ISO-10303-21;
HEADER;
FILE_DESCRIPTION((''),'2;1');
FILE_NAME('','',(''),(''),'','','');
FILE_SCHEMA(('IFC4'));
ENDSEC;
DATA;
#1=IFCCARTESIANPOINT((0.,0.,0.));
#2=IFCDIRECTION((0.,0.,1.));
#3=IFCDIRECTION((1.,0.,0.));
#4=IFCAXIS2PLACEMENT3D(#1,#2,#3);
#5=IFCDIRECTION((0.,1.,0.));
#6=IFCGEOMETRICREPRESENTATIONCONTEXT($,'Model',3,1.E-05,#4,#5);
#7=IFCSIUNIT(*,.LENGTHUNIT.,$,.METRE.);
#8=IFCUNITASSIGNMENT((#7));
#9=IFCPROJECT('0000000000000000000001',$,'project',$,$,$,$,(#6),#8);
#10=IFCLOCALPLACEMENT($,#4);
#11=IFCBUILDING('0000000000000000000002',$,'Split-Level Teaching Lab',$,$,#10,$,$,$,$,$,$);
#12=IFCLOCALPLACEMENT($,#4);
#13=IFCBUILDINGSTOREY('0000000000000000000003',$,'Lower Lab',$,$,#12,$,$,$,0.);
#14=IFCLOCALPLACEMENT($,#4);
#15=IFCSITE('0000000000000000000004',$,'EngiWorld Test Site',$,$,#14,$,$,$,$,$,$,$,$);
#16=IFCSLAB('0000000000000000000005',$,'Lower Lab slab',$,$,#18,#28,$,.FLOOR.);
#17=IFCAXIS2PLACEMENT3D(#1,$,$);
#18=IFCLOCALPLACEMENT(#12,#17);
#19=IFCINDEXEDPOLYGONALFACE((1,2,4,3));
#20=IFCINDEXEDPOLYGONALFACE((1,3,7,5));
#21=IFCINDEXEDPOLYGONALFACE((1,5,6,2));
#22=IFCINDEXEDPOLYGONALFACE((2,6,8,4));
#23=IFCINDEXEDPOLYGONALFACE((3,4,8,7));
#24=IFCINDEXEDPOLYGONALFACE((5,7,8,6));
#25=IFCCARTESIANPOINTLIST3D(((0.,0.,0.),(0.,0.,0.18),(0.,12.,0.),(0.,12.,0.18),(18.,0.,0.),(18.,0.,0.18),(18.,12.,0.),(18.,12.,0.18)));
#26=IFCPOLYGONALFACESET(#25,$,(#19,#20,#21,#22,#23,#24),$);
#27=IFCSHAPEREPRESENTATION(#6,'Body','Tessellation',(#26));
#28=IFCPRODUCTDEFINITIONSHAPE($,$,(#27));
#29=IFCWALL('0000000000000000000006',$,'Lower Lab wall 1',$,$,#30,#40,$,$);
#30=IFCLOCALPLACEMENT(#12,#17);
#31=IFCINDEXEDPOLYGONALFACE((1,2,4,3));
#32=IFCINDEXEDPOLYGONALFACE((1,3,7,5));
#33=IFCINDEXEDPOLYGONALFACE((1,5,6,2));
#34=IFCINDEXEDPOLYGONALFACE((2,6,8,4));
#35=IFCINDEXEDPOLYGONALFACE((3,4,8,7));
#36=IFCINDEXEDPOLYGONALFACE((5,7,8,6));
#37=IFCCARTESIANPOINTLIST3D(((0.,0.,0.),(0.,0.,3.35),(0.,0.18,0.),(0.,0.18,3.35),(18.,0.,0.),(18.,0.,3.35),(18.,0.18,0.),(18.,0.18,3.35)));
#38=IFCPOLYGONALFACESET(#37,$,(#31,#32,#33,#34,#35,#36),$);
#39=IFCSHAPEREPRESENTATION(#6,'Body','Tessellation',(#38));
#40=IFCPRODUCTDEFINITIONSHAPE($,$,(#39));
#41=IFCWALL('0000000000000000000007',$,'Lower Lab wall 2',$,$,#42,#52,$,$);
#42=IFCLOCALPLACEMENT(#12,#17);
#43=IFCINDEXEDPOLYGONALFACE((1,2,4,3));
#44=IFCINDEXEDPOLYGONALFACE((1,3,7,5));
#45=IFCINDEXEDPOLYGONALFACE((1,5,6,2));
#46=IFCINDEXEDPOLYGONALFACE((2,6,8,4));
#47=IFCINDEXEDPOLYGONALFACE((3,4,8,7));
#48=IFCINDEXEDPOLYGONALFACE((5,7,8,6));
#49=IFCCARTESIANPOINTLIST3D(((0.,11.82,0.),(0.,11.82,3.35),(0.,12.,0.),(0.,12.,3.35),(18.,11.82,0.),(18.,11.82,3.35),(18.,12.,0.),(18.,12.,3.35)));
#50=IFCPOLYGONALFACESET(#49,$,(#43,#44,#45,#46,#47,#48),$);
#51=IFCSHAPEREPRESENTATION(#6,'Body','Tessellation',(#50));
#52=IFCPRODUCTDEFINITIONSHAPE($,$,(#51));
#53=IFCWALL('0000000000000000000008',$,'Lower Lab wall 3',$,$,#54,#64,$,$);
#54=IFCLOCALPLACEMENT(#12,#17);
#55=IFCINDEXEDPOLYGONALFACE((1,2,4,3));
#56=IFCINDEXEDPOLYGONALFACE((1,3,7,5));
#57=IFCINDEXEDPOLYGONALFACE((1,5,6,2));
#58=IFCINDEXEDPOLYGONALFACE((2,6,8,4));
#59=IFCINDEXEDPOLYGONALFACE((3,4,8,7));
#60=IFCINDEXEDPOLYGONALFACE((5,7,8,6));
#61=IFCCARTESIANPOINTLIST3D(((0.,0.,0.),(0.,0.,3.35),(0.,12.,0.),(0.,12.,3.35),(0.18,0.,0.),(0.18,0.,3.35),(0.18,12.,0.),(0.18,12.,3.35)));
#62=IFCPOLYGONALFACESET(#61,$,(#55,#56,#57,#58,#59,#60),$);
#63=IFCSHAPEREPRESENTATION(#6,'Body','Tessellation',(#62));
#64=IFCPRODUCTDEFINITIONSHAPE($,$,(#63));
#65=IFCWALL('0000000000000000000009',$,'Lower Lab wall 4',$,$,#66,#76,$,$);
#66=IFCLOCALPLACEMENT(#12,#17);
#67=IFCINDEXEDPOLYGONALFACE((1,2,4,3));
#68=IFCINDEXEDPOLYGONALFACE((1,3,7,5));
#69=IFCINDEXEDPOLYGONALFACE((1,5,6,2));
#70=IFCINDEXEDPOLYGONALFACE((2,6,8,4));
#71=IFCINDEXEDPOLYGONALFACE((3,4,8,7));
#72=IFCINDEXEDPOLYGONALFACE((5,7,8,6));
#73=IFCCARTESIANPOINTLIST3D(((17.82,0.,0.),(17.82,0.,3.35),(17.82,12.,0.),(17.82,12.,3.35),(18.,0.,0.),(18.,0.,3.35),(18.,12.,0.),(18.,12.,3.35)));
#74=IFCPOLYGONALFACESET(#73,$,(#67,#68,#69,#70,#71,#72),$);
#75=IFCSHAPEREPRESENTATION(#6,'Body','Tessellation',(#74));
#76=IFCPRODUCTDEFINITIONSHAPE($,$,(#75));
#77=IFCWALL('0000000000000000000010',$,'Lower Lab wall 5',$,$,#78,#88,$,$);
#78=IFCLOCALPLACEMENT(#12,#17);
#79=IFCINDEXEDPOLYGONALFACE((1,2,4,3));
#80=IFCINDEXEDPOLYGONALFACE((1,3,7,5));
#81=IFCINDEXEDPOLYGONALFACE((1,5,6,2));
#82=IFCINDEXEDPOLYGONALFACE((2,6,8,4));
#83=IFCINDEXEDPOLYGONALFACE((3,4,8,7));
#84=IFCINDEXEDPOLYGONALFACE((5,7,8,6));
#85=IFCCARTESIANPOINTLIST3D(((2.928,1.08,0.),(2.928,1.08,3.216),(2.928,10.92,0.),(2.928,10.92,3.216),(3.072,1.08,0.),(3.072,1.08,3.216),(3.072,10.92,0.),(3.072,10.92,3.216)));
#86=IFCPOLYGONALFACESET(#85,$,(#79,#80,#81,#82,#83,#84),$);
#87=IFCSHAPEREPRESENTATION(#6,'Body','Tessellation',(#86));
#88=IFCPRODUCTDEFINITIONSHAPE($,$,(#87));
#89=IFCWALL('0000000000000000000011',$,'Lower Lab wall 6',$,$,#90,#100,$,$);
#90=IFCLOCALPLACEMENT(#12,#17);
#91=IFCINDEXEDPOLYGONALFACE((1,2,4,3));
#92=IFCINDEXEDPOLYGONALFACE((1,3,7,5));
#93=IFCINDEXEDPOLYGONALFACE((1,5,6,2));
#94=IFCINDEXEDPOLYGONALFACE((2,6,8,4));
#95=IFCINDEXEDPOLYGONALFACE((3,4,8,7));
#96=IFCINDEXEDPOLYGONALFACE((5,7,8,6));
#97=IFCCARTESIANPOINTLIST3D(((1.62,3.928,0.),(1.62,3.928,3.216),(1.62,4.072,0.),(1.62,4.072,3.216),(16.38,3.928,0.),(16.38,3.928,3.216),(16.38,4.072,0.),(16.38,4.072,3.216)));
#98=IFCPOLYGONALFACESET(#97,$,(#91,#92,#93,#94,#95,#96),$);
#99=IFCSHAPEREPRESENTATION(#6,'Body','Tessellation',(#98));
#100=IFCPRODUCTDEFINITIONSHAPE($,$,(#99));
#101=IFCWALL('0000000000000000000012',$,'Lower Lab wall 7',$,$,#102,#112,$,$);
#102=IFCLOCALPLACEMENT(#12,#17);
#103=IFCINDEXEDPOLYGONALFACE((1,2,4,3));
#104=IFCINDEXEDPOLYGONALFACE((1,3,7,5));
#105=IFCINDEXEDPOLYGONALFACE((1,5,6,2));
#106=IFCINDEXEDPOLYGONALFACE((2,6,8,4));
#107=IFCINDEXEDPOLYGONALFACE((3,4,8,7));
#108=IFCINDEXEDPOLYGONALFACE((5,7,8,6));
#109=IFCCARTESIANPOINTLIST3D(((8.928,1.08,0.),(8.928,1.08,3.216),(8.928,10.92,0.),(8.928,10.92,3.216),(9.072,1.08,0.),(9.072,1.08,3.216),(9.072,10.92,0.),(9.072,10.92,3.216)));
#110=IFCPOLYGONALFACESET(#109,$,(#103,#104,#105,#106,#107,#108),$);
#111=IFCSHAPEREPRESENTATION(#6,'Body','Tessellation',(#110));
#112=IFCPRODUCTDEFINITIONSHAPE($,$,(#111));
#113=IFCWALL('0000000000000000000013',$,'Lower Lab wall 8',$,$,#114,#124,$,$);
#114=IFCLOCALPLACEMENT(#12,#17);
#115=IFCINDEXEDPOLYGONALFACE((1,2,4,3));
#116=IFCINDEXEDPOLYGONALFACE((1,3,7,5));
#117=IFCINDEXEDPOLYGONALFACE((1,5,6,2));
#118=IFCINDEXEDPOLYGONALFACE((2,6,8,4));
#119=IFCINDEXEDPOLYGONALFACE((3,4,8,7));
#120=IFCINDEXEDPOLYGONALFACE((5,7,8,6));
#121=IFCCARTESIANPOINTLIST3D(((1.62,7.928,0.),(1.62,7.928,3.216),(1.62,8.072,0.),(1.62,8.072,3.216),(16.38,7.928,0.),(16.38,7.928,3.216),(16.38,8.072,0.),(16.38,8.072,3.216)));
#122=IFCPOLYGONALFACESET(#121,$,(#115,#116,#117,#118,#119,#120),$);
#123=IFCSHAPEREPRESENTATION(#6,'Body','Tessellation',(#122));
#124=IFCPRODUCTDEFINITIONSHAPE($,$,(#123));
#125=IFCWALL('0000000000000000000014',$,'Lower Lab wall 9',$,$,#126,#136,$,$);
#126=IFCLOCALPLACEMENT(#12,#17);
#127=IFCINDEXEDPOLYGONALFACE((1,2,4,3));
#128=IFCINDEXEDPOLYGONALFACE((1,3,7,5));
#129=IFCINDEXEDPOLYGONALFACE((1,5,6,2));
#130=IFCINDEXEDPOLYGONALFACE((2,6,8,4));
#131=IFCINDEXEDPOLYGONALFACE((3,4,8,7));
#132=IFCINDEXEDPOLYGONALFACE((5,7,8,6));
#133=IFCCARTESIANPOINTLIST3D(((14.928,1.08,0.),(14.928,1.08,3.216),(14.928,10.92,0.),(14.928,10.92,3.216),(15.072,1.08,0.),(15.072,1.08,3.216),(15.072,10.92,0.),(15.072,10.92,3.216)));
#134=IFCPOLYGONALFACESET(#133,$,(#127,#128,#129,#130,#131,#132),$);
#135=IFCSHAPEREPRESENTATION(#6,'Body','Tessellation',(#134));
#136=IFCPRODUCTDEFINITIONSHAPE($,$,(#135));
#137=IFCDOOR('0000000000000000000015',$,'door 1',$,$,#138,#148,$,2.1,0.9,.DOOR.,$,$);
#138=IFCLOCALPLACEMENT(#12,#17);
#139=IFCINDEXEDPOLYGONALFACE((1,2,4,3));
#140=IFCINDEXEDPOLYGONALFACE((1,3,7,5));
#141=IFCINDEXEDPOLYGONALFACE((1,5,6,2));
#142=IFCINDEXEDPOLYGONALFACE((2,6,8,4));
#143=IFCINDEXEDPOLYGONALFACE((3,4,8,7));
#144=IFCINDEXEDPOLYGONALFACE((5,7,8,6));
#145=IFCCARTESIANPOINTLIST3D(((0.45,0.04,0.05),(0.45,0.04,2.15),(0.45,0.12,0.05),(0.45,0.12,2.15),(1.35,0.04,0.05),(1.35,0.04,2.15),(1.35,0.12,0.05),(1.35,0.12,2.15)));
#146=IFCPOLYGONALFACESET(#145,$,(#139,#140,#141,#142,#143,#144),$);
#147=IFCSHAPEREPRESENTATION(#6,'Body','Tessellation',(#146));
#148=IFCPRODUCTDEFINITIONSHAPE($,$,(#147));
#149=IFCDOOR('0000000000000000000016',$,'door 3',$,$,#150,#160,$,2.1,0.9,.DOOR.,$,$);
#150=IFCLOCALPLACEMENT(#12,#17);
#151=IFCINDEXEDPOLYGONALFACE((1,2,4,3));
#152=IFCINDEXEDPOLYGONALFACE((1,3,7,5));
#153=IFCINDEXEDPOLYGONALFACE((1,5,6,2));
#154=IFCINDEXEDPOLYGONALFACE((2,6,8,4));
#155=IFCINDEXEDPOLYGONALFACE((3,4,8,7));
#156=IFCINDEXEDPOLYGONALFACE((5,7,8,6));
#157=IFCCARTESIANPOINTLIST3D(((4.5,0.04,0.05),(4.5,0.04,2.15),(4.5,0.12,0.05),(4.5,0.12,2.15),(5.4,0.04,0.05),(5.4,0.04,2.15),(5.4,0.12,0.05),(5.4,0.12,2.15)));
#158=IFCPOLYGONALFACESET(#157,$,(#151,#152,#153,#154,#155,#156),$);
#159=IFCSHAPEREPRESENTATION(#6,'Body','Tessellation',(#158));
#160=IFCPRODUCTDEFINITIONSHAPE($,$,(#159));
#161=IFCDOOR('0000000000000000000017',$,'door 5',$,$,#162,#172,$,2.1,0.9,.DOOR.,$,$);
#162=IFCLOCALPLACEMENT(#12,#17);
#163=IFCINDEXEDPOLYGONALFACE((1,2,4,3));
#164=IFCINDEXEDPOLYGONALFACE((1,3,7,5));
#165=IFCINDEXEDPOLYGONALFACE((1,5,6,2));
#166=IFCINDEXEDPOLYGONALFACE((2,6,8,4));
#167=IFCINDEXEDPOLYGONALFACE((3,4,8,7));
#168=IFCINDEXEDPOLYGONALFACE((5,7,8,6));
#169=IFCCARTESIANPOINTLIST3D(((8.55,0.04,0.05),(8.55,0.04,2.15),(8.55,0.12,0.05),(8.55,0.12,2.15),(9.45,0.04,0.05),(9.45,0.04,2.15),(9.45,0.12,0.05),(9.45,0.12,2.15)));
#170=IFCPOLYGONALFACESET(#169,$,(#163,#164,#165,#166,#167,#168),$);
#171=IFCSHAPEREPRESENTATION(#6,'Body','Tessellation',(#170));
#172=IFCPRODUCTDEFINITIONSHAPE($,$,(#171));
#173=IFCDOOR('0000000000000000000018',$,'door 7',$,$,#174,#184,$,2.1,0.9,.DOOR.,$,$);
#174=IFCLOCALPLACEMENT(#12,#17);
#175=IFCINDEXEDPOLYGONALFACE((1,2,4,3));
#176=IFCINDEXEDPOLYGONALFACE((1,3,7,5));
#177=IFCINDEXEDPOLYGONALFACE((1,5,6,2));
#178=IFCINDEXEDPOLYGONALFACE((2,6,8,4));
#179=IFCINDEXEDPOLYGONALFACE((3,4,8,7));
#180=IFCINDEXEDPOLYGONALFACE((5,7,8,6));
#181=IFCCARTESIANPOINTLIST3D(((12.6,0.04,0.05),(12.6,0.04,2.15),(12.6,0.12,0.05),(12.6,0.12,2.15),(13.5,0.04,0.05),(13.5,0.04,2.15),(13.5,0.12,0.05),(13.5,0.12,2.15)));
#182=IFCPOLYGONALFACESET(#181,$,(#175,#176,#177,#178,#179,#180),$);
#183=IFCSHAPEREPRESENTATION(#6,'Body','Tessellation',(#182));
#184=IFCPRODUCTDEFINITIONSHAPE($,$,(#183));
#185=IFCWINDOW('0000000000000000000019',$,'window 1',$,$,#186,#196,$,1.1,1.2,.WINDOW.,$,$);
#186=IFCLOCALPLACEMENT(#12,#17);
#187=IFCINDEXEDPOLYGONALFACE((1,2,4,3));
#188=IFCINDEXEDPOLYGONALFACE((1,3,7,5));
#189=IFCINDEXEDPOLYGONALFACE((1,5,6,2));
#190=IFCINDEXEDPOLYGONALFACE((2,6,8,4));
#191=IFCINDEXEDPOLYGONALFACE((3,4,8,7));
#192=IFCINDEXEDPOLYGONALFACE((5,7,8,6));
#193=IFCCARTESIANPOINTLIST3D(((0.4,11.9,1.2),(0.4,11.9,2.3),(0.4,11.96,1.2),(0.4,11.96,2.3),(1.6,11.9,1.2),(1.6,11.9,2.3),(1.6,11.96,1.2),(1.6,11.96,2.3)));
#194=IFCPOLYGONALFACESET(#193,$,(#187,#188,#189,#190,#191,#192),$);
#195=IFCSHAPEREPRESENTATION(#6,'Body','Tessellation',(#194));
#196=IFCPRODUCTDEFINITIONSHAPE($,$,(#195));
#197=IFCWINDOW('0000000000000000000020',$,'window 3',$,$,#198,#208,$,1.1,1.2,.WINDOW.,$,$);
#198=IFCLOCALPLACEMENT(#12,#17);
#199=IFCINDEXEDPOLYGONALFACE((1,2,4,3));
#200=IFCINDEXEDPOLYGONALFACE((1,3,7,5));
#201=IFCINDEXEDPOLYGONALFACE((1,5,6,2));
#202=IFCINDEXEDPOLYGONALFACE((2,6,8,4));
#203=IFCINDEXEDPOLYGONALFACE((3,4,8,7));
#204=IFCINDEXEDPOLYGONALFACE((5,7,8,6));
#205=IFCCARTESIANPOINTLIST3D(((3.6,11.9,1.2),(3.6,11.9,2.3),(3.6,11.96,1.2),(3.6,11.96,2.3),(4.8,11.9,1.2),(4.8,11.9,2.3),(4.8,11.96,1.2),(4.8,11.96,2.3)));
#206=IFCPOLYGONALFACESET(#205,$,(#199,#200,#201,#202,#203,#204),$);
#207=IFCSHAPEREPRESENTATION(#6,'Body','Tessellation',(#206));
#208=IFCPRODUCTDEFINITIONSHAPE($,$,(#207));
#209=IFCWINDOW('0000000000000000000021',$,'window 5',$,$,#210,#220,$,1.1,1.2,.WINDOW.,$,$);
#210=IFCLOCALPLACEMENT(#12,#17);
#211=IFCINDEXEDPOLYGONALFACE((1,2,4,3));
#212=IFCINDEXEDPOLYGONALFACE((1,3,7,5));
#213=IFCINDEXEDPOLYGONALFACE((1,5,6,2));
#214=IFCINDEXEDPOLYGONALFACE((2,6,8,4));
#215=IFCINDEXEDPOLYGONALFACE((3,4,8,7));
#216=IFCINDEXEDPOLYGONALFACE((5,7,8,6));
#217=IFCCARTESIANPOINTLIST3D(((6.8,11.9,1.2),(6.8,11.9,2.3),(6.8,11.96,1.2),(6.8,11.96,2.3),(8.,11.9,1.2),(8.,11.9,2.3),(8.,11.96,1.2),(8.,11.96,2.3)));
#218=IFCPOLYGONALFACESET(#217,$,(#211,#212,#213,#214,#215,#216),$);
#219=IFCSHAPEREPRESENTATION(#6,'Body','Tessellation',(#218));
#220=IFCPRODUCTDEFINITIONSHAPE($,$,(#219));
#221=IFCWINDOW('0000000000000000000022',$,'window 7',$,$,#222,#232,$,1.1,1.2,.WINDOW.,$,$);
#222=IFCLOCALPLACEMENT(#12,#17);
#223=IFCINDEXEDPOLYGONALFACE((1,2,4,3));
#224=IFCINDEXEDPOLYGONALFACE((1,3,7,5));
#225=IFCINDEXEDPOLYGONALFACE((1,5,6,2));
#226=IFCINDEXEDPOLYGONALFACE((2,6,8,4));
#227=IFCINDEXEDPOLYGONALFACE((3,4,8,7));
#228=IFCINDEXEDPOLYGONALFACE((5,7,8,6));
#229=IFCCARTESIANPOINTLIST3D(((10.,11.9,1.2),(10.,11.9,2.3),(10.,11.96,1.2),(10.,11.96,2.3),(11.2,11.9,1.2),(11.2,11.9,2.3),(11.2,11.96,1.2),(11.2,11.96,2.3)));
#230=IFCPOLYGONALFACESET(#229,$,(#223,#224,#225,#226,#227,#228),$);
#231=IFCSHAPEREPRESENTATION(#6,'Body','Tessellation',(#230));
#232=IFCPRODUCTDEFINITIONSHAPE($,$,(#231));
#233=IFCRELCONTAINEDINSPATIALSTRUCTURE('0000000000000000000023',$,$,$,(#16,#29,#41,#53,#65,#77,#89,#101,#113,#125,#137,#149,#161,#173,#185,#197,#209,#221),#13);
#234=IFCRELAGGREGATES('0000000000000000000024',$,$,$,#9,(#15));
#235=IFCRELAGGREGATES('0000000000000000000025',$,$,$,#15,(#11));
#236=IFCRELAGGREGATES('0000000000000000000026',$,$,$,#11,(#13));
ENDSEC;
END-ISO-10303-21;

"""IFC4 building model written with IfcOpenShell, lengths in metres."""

from ifc_helpers import new_model, si_unit, direction, frame, origin_with_axes, origin_2d_with_axis, place, context, project, spatial, rectangle, extrude, element, save


model = new_model("IFC4")

# Units and contexts
model_context = context("Model", 3, precision=1e-05, world=origin_with_axes(), true_north=direction((0.0, 1.0, 0.0)))
ifc_project = project(units=[si_unit("LENGTHUNIT", "METRE")], contexts=[model_context])

# Site, building, storey
site_placement = place(None, origin_with_axes())
site = spatial("IfcSite", under=ifc_project, at=site_placement, Name="EngiWorld Test Site")
building_placement = place(None, origin_with_axes())
building = spatial("IfcBuilding", under=site, at=building_placement, Name="Split-Level Teaching Lab")
storey_placement = place(None, origin_with_axes())
storey = spatial("IfcBuildingStorey", under=building, at=storey_placement, Name="Lower Lab", Elevation=0.0)

# Slab
slab_placement = place(None, frame((9.0, 6.0, 0.0), z_axis=(0.0, 0.0, 1.0), x_axis=(1.0, 0.0, 0.0)))
element("IfcSlab", 1, at=slab_placement, inside=storey, Name="Lower Lab slab", PredefinedType="FLOOR", context=model_context, shape_type="SweptSolid", body=[
    extrude(rectangle(XDim=18.0, YDim=12.0, at=origin_2d_with_axis()), origin_with_axes(), (0.0, 0.0, 1.0), 0.18),
])

# Walls
for number, where, z_axis, x_axis, name in (
    (2, (9.0, 0.09, 0.0), (0.0, 0.0, 1.0), (1.0, 0.0, 0.0), "Lower Lab wall 1"),
    (3, (9.0, 11.91, 0.0), (0.0, 0.0, 1.0), (1.0, 0.0, 0.0), "Lower Lab wall 2"),
):
    element("IfcWall", number, at=place(None, frame(where, z_axis=z_axis, x_axis=x_axis)), inside=storey, Name=name, context=model_context, shape_type="SweptSolid", body=[
        extrude(rectangle(XDim=18.0, YDim=0.18, at=origin_2d_with_axis()), origin_with_axes(), (0.0, 0.0, 1.0), 3.35),
    ])
for number, where, z_axis, x_axis, name in (
    (4, (0.09, 6.0, 0.0), (0.0, 0.0, 1.0), (1.0, 0.0, 0.0), "Lower Lab wall 3"),
    (5, (17.91, 6.0, 0.0), (0.0, 0.0, 1.0), (1.0, 0.0, 0.0), "Lower Lab wall 4"),
):
    element("IfcWall", number, at=place(None, frame(where, z_axis=z_axis, x_axis=x_axis)), inside=storey, Name=name, context=model_context, shape_type="SweptSolid", body=[
        extrude(rectangle(XDim=0.18, YDim=12.0, at=origin_2d_with_axis()), origin_with_axes(), (0.0, 0.0, 1.0), 3.35),
    ])
wall_1_placement = place(None, frame((3.0, 6.0, 0.0), z_axis=(0.0, 0.0, 1.0), x_axis=(1.0, 0.0, 0.0)))
element("IfcWall", 6, at=wall_1_placement, inside=storey, Name="Lower Lab wall 5", context=model_context, shape_type="SweptSolid", body=[
    extrude(rectangle(XDim=0.144, YDim=9.84, at=origin_2d_with_axis()), origin_with_axes(), (0.0, 0.0, 1.0), 3.216),
])
wall_2_placement = place(None, frame((9.0, 4.0, 0.0), z_axis=(0.0, 0.0, 1.0), x_axis=(1.0, 0.0, 0.0)))
element("IfcWall", 7, at=wall_2_placement, inside=storey, Name="Lower Lab wall 6", context=model_context, shape_type="SweptSolid", body=[
    extrude(rectangle(XDim=14.76, YDim=0.144, at=origin_2d_with_axis()), origin_with_axes(), (0.0, 0.0, 1.0), 3.216),
])
wall_3_placement = place(None, frame((9.0, 6.0, 0.0), z_axis=(0.0, 0.0, 1.0), x_axis=(1.0, 0.0, 0.0)))
element("IfcWall", 8, at=wall_3_placement, inside=storey, Name="Lower Lab wall 7", context=model_context, shape_type="SweptSolid", body=[
    extrude(rectangle(XDim=0.144, YDim=9.84, at=origin_2d_with_axis()), origin_with_axes(), (0.0, 0.0, 1.0), 3.216),
])
wall_4_placement = place(None, frame((9.0, 8.0, 0.0), z_axis=(0.0, 0.0, 1.0), x_axis=(1.0, 0.0, 0.0)))
element("IfcWall", 9, at=wall_4_placement, inside=storey, Name="Lower Lab wall 8", context=model_context, shape_type="SweptSolid", body=[
    extrude(rectangle(XDim=14.76, YDim=0.144, at=origin_2d_with_axis()), origin_with_axes(), (0.0, 0.0, 1.0), 3.216),
])
wall_5_placement = place(None, frame((15.0, 6.0, 0.0), z_axis=(0.0, 0.0, 1.0), x_axis=(1.0, 0.0, 0.0)))
element("IfcWall", 10, at=wall_5_placement, inside=storey, Name="Lower Lab wall 9", context=model_context, shape_type="SweptSolid", body=[
    extrude(rectangle(XDim=0.144, YDim=9.84, at=origin_2d_with_axis()), origin_with_axes(), (0.0, 0.0, 1.0), 3.216),
])

# Doors
for number, where, z_axis, x_axis, name in (
    (11, (0.9, 0.08, 0.05), (0.0, 0.0, 1.0), (1.0, 0.0, 0.0), "door 1"),
    (12, (4.95, 0.08, 0.05), (0.0, 0.0, 1.0), (1.0, 0.0, 0.0), "door 3"),
    (13, (9.0, 0.08, 0.05), (0.0, 0.0, 1.0), (1.0, 0.0, 0.0), "door 5"),
    (14, (13.05, 0.08, 0.05), (0.0, 0.0, 1.0), (1.0, 0.0, 0.0), "door 7"),
):
    element("IfcDoor", number, at=place(None, frame(where, z_axis=z_axis, x_axis=x_axis)), inside=storey, Name=name, OverallHeight=2.1, OverallWidth=0.9, PredefinedType="DOOR", context=model_context, shape_type="SweptSolid", body=[
        extrude(rectangle(XDim=0.9, YDim=0.08, at=origin_2d_with_axis()), origin_with_axes(), (0.0, 0.0, 1.0), 2.1),
    ])

# Windows
for number, where, z_axis, x_axis, name in (
    (15, (1.0, 11.93, 1.2), (0.0, 0.0, 1.0), (1.0, 0.0, 0.0), "window 1"),
    (16, (4.2, 11.93, 1.2), (0.0, 0.0, 1.0), (1.0, 0.0, 0.0), "window 3"),
    (17, (7.4, 11.93, 1.2), (0.0, 0.0, 1.0), (1.0, 0.0, 0.0), "window 5"),
    (18, (10.6, 11.93, 1.2), (0.0, 0.0, 1.0), (1.0, 0.0, 0.0), "window 7"),
):
    element("IfcWindow", number, at=place(None, frame(where, z_axis=z_axis, x_axis=x_axis)), inside=storey, Name=name, OverallHeight=1.1, OverallWidth=1.2, PredefinedType="WINDOW", context=model_context, shape_type="SweptSolid", body=[
        extrude(rectangle(XDim=1.2, YDim=0.06, at=origin_2d_with_axis()), origin_with_axes(), (0.0, 0.0, 1.0), 1.1),
    ])

save(model, "model.ifc")
